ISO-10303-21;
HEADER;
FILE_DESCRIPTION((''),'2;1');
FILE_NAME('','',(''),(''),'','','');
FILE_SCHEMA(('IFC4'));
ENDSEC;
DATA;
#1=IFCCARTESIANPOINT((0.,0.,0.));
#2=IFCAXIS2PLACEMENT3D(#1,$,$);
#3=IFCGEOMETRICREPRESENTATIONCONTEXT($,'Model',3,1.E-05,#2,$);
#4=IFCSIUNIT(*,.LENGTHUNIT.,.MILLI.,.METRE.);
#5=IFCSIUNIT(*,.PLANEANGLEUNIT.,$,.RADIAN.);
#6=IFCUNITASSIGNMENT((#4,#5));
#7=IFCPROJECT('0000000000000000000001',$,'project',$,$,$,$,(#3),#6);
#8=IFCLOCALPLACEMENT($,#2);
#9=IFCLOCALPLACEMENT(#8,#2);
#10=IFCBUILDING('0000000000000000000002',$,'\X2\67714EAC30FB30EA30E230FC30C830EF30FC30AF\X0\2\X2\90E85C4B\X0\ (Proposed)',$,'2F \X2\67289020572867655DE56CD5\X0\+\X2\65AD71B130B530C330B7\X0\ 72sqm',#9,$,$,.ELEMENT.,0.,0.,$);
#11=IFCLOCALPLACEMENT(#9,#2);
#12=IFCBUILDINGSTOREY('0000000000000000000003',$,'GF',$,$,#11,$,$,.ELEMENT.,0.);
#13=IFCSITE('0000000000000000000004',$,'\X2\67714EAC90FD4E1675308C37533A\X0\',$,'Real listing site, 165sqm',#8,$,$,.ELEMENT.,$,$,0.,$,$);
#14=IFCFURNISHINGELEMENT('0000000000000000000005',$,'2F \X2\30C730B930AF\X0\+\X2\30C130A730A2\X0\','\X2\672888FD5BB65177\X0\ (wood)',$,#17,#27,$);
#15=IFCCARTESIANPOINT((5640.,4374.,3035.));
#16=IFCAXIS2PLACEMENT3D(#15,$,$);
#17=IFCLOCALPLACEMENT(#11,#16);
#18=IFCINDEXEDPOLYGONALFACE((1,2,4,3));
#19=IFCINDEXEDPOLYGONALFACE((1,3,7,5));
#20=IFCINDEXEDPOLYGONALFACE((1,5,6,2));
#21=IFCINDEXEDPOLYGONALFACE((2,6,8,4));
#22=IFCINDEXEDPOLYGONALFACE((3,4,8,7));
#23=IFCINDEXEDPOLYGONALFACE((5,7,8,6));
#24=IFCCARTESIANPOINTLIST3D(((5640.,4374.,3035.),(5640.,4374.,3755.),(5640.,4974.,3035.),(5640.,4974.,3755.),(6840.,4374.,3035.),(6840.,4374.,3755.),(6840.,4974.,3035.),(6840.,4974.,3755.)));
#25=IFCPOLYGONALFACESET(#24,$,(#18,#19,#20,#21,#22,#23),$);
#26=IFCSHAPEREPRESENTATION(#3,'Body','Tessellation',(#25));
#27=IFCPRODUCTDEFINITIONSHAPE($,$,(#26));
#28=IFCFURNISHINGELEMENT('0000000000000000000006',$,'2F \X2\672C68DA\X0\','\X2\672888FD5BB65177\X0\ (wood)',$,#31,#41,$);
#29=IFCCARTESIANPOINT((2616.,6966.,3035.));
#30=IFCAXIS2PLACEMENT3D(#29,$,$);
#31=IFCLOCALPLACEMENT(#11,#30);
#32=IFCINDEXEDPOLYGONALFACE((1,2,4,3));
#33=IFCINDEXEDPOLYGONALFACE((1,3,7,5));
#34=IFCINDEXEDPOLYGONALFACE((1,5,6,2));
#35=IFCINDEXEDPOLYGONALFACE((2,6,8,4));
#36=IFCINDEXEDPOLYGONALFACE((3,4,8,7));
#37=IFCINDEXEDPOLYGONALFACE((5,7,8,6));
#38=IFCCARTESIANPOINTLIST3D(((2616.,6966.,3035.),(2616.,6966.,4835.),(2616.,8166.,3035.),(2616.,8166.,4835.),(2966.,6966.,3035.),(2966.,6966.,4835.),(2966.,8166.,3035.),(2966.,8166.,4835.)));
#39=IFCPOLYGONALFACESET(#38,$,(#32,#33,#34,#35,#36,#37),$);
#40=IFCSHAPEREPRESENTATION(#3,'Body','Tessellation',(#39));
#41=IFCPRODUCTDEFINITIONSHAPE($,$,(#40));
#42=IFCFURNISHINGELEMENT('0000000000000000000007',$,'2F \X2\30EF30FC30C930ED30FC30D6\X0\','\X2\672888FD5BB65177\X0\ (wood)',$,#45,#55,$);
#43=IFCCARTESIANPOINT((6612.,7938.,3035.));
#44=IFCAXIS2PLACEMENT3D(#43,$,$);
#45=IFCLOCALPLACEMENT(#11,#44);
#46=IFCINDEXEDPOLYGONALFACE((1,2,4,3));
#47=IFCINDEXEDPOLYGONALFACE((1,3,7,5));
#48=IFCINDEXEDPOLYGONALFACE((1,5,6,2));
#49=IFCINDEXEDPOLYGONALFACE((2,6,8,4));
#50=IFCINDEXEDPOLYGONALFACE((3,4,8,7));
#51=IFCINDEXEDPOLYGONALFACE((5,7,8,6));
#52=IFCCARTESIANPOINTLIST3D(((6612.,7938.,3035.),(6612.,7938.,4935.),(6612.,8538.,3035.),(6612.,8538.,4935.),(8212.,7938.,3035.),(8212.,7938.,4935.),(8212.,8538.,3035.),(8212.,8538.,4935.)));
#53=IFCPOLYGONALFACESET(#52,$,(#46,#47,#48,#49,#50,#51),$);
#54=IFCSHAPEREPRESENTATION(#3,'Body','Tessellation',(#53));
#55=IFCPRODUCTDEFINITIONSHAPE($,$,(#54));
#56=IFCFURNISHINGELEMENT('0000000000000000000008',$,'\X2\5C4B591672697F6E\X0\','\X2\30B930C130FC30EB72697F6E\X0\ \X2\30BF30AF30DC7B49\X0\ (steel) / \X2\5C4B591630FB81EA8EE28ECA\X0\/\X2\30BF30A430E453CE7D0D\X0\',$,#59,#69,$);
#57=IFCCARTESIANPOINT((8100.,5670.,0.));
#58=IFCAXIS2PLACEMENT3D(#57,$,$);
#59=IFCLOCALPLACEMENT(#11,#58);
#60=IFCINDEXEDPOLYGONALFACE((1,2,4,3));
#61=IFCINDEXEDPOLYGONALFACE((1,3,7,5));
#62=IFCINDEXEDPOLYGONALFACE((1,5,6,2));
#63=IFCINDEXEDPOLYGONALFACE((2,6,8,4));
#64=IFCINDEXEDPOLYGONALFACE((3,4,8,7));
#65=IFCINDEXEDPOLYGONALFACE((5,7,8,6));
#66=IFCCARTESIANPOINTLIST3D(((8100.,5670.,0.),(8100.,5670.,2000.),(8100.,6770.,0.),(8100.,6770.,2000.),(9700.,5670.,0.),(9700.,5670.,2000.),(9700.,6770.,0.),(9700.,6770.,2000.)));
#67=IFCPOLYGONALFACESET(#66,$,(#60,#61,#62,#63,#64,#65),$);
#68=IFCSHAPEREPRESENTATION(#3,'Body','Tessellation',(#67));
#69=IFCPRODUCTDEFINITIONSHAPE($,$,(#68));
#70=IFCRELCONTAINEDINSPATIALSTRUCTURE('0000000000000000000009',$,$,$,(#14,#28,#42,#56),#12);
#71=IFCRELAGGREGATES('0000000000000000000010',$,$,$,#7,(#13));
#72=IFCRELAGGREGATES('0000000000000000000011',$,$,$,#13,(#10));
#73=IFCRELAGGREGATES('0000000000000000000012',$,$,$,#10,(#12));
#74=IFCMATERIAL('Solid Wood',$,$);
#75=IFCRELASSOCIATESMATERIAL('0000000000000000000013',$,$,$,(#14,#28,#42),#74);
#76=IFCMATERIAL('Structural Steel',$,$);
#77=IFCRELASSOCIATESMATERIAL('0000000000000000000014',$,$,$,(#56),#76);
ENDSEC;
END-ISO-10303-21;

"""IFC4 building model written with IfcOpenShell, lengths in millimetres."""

from ifc_helpers import new_model, si_unit, frame, frame_2d, origin, place, context, project, spatial, rectangle, extrude, material, element, save


model = new_model("IFC4")

# Units and contexts
model_context = context("Model", 3, precision=1e-05, world=origin())
ifc_project = project(units=[si_unit("LENGTHUNIT", "METRE", prefix="MILLI"), si_unit("PLANEANGLEUNIT", "RADIAN")], contexts=[model_context])

# Site, building, storey
site_placement = place(None, origin())
site = spatial("IfcSite", under=ifc_project, at=site_placement, Name="東京都世田谷区", ObjectType="Real listing site, 165sqm", CompositionType="ELEMENT", RefElevation=0.0)
building_placement = place(site_placement, origin())
building = spatial("IfcBuilding", under=site, at=building_placement, Name="東京・リモートワーク2部屋 (Proposed)", ObjectType="2F 木造在来工法+断熱サッシ 72sqm", CompositionType="ELEMENT", ElevationOfRefHeight=0.0, ElevationOfTerrain=0.0)
storey_placement = place(building_placement, origin())
storey = spatial("IfcBuildingStorey", under=building, at=storey_placement, Name="GF", CompositionType="ELEMENT", Elevation=0.0)

# Shared definitions
ifc_material_1 = material(Name="Solid Wood")

# Shared definitions
ifc_material_2 = material(Name="Structural Steel")

# Furnishing elements
furnishing_1_placement = place(storey_placement, frame((5640.0, 4374.0, 3035.0)))
element("IfcFurnishingElement", 1, at=furnishing_1_placement, inside=storey, material=ifc_material_1, Name="2F デスク+チェア", Description="木製家具 (wood)", context=model_context, shape_type="SweptSolid", body=[
    extrude(rectangle(XDim=1200.0, YDim=600.0, at=frame_2d((600.0, 300.0))), frame((5640.0, 4374.0, 3035.0)), (0.0, 0.0, 1.0), 720.0),
])
furnishing_2_placement = place(storey_placement, frame((2616.0, 6966.0, 3035.0)))
element("IfcFurnishingElement", 2, at=furnishing_2_placement, inside=storey, material=ifc_material_1, Name="2F 本棚", Description="木製家具 (wood)", context=model_context, shape_type="SweptSolid", body=[
    extrude(rectangle(XDim=350.0, YDim=1200.0, at=frame_2d((175.0, 600.0))), frame((2616.0, 6966.0, 3035.0)), (0.0, 0.0, 1.0), 1800.0),
])
furnishing_3_placement = place(storey_placement, frame((6612.0, 7938.0, 3035.0)))
element("IfcFurnishingElement", 3, at=furnishing_3_placement, inside=storey, material=ifc_material_1, Name="2F ワードローブ", Description="木製家具 (wood)", context=model_context, shape_type="SweptSolid", body=[
    extrude(rectangle(XDim=1600.0, YDim=600.0, at=frame_2d((800.0, 300.0))), frame((6612.0, 7938.0, 3035.0)), (0.0, 0.0, 1.0), 1900.0),
])
furnishing_4_placement = place(storey_placement, frame((8100.0, 5670.0, 0.0)))
element("IfcFurnishingElement", 4, at=furnishing_4_placement, inside=storey, material=ifc_material_2, Name="屋外物置", Description="スチール物置 タクボ等 (steel) / 屋外・自転車/タイヤ収納", context=model_context, shape_type="SweptSolid", body=[
    extrude(rectangle(XDim=1600.0, YDim=1100.0, at=frame_2d((800.0, 550.0))), frame((8100.0, 5670.0, 0.0)), (0.0, 0.0, 1.0), 2000.0),
])

save(model, "model.ifc")
